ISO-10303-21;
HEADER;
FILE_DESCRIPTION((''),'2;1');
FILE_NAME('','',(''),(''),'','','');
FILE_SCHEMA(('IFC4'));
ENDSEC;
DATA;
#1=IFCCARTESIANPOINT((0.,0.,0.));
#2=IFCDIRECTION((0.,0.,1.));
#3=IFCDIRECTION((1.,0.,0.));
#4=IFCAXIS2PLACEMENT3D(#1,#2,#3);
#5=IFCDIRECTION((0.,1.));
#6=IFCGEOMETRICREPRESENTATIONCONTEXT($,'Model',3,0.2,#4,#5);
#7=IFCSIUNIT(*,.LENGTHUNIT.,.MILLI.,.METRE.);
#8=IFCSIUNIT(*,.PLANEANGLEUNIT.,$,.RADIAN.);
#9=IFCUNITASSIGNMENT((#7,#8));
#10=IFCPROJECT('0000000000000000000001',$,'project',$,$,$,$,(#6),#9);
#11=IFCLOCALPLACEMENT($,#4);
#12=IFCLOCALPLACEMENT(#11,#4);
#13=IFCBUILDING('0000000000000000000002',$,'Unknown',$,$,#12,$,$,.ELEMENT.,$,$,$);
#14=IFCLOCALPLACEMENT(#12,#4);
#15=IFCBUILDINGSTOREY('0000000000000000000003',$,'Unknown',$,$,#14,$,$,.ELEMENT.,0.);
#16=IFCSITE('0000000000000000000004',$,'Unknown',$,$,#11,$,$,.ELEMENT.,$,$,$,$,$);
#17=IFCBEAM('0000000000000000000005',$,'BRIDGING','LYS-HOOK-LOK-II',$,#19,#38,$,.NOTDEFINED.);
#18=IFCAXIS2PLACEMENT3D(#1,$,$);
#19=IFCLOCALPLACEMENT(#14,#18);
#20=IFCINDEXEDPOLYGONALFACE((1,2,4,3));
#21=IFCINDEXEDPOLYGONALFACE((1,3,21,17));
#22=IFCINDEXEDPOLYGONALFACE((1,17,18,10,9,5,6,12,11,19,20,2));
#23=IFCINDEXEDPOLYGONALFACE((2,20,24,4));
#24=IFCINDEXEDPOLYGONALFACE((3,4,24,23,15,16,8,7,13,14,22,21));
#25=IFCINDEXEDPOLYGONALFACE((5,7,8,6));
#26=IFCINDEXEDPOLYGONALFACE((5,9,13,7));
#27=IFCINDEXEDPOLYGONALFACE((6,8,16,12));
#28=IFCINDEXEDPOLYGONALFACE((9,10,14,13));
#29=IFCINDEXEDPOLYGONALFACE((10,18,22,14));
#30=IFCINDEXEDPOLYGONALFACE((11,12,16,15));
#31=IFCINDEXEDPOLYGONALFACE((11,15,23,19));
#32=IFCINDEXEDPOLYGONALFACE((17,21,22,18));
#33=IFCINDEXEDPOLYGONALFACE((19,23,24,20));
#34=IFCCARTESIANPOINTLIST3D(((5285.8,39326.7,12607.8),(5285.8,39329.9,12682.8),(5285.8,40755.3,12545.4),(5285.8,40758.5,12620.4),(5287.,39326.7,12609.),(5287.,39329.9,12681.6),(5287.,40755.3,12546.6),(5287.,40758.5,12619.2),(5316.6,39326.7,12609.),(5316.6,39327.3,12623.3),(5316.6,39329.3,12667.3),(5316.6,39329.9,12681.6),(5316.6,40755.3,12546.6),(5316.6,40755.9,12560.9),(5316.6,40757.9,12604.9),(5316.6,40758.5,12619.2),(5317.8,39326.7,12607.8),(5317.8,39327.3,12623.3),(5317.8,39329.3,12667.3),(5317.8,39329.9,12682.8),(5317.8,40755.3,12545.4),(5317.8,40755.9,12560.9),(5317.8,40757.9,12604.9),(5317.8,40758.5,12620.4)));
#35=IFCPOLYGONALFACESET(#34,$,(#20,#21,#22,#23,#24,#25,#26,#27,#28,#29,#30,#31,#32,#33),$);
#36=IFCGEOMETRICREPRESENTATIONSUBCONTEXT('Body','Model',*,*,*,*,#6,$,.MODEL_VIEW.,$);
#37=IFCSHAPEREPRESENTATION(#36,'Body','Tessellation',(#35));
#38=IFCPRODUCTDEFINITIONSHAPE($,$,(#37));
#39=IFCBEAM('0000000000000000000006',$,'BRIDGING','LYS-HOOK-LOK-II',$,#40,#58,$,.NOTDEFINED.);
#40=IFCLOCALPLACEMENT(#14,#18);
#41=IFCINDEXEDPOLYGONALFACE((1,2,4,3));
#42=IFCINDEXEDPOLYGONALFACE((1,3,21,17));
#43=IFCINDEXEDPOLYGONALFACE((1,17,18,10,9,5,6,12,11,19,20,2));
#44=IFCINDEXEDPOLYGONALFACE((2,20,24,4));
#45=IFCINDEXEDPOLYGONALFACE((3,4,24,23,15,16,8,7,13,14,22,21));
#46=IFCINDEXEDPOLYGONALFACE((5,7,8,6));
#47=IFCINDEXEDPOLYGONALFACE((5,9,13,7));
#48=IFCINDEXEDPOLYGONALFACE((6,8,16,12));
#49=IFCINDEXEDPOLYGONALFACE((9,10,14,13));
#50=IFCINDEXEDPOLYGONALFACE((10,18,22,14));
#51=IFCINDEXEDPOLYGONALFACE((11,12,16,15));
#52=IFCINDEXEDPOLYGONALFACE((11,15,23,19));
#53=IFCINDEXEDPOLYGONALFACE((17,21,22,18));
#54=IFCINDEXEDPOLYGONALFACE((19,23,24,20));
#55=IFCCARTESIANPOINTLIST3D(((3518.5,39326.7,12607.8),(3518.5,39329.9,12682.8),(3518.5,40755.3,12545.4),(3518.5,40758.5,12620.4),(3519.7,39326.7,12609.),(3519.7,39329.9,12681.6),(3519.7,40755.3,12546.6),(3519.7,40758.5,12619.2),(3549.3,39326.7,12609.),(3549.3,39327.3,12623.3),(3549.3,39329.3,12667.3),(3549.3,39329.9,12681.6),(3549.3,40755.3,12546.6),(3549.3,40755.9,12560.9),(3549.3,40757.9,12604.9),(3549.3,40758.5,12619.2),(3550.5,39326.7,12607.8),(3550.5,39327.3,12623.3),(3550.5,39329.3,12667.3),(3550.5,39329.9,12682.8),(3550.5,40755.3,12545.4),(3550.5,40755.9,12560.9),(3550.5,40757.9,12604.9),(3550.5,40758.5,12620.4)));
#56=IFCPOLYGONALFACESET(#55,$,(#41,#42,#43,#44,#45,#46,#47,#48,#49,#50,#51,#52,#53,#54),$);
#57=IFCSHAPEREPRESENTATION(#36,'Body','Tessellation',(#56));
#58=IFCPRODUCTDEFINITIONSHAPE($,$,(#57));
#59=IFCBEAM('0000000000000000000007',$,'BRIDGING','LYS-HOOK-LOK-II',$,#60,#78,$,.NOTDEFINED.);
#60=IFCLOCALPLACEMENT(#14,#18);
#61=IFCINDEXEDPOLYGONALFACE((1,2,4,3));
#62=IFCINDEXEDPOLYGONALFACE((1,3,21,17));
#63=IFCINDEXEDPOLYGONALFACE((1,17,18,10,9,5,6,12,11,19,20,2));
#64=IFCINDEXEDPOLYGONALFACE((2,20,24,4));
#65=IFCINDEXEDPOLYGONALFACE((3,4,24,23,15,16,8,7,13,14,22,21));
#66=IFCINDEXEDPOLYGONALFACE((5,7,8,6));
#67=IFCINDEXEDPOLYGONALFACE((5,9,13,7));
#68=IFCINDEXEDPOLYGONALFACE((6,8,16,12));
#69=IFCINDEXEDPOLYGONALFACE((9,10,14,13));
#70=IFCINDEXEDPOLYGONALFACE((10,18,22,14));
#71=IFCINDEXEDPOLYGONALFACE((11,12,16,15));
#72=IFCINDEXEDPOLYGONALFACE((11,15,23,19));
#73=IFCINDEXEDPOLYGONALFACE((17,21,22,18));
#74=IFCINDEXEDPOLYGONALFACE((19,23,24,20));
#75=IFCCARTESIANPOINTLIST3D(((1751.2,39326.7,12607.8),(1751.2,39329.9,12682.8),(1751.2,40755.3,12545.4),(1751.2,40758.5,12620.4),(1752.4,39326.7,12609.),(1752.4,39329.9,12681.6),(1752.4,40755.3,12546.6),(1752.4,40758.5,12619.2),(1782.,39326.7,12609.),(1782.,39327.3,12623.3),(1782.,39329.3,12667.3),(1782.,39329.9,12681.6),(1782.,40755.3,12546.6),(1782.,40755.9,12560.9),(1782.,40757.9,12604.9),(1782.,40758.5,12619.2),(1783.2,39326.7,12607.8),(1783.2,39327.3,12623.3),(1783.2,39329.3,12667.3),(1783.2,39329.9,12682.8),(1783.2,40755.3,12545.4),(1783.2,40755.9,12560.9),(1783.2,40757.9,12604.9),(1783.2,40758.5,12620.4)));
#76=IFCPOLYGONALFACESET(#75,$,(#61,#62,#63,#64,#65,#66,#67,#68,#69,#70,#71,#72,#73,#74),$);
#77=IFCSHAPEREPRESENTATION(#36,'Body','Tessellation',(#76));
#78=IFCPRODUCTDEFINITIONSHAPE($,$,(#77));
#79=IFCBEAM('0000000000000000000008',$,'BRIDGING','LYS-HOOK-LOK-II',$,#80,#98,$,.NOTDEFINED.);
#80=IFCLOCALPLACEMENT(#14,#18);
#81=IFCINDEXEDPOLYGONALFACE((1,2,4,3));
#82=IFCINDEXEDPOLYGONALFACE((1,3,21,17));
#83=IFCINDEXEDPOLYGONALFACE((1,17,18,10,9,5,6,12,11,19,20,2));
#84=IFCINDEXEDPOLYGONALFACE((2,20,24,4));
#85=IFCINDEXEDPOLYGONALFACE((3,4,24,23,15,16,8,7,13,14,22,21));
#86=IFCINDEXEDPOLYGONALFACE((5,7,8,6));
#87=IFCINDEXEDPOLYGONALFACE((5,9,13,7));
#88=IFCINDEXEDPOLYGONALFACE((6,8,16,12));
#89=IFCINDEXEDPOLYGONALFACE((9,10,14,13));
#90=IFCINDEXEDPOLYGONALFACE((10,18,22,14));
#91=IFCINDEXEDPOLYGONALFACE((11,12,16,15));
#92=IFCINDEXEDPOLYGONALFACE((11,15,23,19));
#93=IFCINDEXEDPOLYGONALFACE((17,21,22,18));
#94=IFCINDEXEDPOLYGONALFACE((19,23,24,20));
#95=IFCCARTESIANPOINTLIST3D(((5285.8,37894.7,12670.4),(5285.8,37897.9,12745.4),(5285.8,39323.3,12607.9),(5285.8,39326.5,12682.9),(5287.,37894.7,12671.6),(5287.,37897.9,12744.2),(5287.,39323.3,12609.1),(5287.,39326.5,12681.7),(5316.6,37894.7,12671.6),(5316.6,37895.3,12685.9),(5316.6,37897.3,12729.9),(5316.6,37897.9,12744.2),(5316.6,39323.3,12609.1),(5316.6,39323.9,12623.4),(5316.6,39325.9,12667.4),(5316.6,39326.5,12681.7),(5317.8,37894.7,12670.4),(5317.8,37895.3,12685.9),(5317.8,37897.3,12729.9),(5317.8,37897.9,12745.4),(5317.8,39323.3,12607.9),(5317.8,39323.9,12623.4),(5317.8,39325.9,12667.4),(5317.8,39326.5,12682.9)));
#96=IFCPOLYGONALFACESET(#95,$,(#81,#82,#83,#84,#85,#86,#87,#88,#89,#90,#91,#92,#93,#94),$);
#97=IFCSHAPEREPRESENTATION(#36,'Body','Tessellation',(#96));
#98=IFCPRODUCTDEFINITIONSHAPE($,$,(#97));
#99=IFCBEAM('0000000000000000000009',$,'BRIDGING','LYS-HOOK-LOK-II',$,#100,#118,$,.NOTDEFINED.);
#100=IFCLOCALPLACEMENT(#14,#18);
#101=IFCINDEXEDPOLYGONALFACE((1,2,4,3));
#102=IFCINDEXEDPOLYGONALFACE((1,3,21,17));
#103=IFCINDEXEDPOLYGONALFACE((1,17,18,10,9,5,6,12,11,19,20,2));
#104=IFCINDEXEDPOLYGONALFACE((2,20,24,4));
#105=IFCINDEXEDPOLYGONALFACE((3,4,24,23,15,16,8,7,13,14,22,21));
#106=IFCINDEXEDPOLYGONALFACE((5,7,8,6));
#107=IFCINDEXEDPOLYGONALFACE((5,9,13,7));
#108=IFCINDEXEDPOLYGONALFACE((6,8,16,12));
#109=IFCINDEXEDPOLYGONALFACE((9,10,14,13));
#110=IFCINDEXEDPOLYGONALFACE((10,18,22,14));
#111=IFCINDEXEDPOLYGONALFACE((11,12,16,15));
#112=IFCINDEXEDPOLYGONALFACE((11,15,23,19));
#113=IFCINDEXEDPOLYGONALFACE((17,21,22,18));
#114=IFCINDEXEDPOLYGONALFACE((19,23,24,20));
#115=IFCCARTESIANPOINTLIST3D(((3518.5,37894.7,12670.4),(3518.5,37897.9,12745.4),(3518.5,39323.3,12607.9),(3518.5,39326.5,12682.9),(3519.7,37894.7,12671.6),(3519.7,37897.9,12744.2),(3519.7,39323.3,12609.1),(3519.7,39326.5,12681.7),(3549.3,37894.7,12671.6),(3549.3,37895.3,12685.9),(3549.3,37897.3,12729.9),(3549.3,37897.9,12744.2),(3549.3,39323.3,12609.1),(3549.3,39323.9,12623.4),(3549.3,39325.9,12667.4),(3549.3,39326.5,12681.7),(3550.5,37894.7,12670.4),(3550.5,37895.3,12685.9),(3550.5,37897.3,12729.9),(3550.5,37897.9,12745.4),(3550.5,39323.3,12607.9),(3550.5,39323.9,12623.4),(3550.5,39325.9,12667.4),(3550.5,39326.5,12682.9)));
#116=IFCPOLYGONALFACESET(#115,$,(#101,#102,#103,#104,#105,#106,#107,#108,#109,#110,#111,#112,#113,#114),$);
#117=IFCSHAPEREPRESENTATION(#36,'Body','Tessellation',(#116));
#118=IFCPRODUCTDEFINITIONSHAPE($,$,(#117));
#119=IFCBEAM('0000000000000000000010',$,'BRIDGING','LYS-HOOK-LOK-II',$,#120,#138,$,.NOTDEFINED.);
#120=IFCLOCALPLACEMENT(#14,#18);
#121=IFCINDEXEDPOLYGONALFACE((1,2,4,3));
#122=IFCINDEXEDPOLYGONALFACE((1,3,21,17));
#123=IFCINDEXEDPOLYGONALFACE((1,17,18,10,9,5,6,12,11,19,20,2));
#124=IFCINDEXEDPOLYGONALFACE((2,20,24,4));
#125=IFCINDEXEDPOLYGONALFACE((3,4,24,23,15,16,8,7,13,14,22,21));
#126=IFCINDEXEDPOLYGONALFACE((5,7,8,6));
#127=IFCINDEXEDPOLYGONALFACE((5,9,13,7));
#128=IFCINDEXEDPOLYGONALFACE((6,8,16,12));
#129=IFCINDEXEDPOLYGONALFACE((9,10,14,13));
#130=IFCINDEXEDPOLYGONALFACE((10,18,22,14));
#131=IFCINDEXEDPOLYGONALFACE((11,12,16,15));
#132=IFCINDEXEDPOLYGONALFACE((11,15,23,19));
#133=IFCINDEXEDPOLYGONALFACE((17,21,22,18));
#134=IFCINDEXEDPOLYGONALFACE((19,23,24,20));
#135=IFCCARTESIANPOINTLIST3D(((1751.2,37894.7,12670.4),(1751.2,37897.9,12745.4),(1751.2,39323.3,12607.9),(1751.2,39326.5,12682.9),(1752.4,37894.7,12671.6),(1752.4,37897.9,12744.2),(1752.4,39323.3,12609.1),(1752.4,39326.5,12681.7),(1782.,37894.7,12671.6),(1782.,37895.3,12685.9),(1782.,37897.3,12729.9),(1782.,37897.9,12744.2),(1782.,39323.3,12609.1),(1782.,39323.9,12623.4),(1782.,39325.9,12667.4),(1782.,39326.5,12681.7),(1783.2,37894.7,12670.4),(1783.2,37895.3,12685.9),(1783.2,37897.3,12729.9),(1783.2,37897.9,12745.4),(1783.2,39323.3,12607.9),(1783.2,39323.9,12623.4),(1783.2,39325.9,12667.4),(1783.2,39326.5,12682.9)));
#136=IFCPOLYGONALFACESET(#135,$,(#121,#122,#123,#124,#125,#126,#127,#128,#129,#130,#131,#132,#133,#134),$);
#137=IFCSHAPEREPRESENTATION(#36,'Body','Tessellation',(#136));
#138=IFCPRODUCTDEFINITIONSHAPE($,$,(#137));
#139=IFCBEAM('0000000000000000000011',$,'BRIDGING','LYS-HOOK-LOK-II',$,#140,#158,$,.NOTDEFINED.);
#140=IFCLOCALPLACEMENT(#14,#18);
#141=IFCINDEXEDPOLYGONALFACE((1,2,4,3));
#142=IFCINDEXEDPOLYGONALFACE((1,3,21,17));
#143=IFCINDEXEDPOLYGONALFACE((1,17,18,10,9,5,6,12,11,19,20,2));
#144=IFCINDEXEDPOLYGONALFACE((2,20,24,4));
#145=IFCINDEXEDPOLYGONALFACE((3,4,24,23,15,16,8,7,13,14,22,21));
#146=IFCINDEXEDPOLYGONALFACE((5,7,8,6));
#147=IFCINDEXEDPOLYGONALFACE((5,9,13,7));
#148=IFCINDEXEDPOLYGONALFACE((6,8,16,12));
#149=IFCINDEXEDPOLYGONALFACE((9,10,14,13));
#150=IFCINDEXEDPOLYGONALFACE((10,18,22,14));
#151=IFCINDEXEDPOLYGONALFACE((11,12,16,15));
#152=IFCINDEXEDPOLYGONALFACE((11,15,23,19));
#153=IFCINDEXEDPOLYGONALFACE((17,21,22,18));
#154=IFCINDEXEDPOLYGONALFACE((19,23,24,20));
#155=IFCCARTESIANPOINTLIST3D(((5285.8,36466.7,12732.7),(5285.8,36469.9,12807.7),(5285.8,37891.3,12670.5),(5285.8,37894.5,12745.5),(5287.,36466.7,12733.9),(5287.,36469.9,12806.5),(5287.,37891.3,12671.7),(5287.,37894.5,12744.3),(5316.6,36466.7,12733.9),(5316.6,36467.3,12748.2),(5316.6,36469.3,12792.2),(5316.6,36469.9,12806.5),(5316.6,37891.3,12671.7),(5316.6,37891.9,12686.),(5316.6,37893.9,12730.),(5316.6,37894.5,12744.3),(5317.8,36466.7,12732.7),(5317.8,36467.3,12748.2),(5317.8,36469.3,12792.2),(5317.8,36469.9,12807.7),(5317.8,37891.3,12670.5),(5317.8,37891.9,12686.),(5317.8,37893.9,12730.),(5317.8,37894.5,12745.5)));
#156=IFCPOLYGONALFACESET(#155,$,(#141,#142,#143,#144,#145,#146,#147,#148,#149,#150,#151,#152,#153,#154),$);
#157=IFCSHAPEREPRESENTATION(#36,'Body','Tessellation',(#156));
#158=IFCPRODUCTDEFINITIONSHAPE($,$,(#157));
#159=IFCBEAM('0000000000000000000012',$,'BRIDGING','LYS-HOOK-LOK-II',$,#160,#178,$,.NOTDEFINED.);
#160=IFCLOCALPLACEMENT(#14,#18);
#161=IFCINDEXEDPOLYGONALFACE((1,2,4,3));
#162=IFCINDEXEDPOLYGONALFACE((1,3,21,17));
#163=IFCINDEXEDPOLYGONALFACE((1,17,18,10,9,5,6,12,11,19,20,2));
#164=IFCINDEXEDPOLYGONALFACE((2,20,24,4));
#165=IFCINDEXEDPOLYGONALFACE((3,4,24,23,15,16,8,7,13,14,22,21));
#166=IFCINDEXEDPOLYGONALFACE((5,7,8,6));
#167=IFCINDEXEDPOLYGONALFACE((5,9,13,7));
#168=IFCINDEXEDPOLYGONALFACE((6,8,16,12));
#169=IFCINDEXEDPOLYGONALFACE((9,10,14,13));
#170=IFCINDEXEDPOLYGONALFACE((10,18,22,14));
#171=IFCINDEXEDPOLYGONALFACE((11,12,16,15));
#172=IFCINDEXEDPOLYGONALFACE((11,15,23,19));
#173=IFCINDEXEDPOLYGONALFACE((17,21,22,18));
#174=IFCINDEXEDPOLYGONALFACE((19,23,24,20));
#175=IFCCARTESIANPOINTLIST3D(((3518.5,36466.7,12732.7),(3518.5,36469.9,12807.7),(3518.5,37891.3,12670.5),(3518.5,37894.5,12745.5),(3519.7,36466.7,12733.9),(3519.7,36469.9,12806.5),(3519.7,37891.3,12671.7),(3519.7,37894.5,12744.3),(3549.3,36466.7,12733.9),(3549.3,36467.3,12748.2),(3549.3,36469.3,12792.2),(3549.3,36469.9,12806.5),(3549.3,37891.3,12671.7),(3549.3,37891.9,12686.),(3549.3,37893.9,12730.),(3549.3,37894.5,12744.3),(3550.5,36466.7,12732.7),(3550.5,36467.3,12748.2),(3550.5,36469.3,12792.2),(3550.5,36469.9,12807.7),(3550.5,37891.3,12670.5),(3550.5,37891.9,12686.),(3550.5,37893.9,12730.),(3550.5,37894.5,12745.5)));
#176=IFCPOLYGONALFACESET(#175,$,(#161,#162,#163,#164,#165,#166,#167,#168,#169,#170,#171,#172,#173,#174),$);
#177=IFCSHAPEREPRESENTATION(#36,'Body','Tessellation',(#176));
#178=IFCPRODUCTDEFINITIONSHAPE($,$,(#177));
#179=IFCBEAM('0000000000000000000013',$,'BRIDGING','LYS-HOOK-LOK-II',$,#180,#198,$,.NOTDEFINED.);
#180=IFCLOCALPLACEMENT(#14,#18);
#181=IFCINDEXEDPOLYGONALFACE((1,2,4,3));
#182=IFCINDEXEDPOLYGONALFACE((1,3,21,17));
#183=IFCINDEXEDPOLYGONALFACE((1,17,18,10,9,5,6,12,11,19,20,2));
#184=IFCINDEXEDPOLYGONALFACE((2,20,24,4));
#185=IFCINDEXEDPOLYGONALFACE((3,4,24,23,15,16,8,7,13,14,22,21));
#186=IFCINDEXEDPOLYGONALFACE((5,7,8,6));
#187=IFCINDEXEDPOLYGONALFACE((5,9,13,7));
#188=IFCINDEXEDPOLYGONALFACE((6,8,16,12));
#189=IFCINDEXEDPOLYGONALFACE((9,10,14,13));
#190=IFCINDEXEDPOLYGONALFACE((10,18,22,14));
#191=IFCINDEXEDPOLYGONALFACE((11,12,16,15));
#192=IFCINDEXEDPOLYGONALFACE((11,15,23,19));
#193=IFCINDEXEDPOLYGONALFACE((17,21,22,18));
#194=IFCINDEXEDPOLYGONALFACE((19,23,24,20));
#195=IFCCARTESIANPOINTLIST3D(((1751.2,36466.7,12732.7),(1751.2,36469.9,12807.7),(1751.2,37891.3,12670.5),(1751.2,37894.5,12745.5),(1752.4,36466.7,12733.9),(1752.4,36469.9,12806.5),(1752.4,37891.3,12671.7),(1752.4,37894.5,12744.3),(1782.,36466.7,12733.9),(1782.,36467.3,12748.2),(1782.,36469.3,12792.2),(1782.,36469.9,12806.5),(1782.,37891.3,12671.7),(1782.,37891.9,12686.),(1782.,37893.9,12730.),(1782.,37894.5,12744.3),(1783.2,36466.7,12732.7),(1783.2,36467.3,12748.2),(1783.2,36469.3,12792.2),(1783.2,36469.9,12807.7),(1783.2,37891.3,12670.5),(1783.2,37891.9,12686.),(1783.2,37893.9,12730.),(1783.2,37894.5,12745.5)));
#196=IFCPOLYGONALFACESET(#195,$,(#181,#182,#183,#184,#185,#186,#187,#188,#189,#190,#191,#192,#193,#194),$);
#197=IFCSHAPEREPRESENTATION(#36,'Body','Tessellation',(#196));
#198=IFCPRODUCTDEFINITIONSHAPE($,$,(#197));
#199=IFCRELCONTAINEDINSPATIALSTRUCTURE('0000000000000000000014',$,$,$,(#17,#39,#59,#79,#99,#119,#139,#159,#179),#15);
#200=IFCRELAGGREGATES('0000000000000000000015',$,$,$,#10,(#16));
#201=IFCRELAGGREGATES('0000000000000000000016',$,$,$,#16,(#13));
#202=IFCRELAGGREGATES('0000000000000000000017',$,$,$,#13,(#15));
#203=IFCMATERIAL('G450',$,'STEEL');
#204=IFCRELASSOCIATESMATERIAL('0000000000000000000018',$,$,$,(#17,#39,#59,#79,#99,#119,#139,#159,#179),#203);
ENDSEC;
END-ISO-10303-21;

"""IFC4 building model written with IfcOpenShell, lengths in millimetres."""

from ifc_helpers import new_model, si_unit, direction, frame, origin_with_axes, place, context, subcontext, project, spatial, line, indexed_curve, outline, extrude, material, element, save


model = new_model("IFC4")

# Units and contexts
model_context = context("Model", 3, precision=0.2, world=origin_with_axes(), true_north=direction((0.0, 1.0)))
body_context = subcontext(model_context, "Body", "Model", "MODEL_VIEW")
ifc_project = project(units=[si_unit("LENGTHUNIT", "METRE", prefix="MILLI"), si_unit("PLANEANGLEUNIT", "RADIAN")], contexts=[model_context])

# Site, building, storey
site_placement = place(None, origin_with_axes())
site = spatial("IfcSite", under=ifc_project, at=site_placement, Name="Unknown", CompositionType="ELEMENT")
building_placement = place(site_placement, origin_with_axes())
building = spatial("IfcBuilding", under=site, at=building_placement, Name="Unknown", CompositionType="ELEMENT")
storey_placement = place(building_placement, origin_with_axes())
storey = spatial("IfcBuildingStorey", under=building, at=storey_placement, Name="Unknown", CompositionType="ELEMENT", Elevation=0.0)

# Beams
ifc_material_1 = material(Name="G450", Category="STEEL")
for number, where, z_axis, x_axis, name in (
    (1, (5301.8, 39328.3, 12645.3), (1.0, 0.0, 0.0), (0.0, 0.999047, -0.043638), "BRIDGING"),
    (2, (3534.5, 39328.3, 12645.3), (1.0, 0.0, 0.0), (0.0, 0.999047, -0.043638), "BRIDGING"),
    (3, (1767.2, 39328.3, 12645.3), (1.0, 0.0, 0.0), (0.0, 0.999047, -0.043638), "BRIDGING"),
):
    element("IfcBeam", number, at=place(storey_placement, frame(where, z_axis=z_axis, x_axis=x_axis)), inside=storey, material=ifc_material_1, Name=name, Description="LYS-HOOK-LOK-II", PredefinedType="NOTDEFINED", context=body_context, shape_type="SolidModel", body=[
        extrude(outline(indexed_curve([(16.0, -37.5), (16.0, -22.0), (14.8, -22.0), (14.8, -36.3), (-14.8, -36.3), (-14.8, 36.3), (14.8, 36.3), (14.8, 22.0), (16.0, 22.0), (16.0, 37.5), (-16.0, 37.5), (-16.0, -37.5)], segments=[line(1, 2, 3, 4, 5, 6, 7, 8, 9, 10, 11, 12, 1)])), frame((0.0, 0.0, 0.0), z_axis=(-1.0, 0.0, 0.0), x_axis=(0.0, 0.0, 1.0)), (0.0, 0.0, -1.0), 1430.0),
    ])
for number, where, z_axis, x_axis, name in (
    (4, (5301.8, 37896.3, 12707.9), (1.0, 0.0, 0.0), (0.0, 0.999044, -0.043707), "BRIDGING"),
    (5, (3534.5, 37896.3, 12707.9), (1.0, 0.0, 0.0), (0.0, 0.999044, -0.043707), "BRIDGING"),
    (6, (1767.2, 37896.3, 12707.9), (1.0, 0.0, 0.0), (0.0, 0.999044, -0.043707), "BRIDGING"),
):
    element("IfcBeam", number, at=place(storey_placement, frame(where, z_axis=z_axis, x_axis=x_axis)), inside=storey, material=ifc_material_1, Name=name, Description="LYS-HOOK-LOK-II", PredefinedType="NOTDEFINED", context=body_context, shape_type="SolidModel", body=[
        extrude(outline(indexed_curve([(16.0, -37.5), (16.0, -22.0), (14.8, -22.0), (14.8, -36.3), (-14.8, -36.3), (-14.8, 36.3), (14.8, 36.3), (14.8, 22.0), (16.0, 22.0), (16.0, 37.5), (-16.0, 37.5), (-16.0, -37.5)], segments=[line(1, 2, 3, 4, 5, 6, 7, 8, 9, 10, 11, 12, 1)])), frame((0.0, 0.0, 0.0), z_axis=(-1.0, 0.0, 0.0), x_axis=(0.0, 0.0, 1.0)), (0.0, 0.0, -1.0), 1430.0),
    ])
for number, where, z_axis, x_axis, name in (
    (7, (5301.8, 36468.3, 12770.2), (1.0, 0.0, 0.0), (0.0, 0.999048, -0.04362), "BRIDGING"),
    (8, (3534.5, 36468.3, 12770.2), (1.0, 0.0, 0.0), (0.0, 0.999048, -0.04362), "BRIDGING"),
    (9, (1767.2, 36468.3, 12770.2), (1.0, 0.0, 0.0), (0.0, 0.999048, -0.04362), "BRIDGING"),
):
    element("IfcBeam", number, at=place(storey_placement, frame(where, z_axis=z_axis, x_axis=x_axis)), inside=storey, material=ifc_material_1, Name=name, Description="LYS-HOOK-LOK-II", PredefinedType="NOTDEFINED", context=body_context, shape_type="SolidModel", body=[
        extrude(outline(indexed_curve([(16.0, -37.5), (16.0, -22.0), (14.8, -22.0), (14.8, -36.3), (-14.8, -36.3), (-14.8, 36.3), (14.8, 36.3), (14.8, 22.0), (16.0, 22.0), (16.0, 37.5), (-16.0, 37.5), (-16.0, -37.5)], segments=[line(1, 2, 3, 4, 5, 6, 7, 8, 9, 10, 11, 12, 1)])), frame((0.0, 0.0, 0.0), z_axis=(-1.0, 0.0, 0.0), x_axis=(0.0, 0.0, 1.0)), (0.0, 0.0, -1.0), 1426.0),
    ])

save(model, "model.ifc")
